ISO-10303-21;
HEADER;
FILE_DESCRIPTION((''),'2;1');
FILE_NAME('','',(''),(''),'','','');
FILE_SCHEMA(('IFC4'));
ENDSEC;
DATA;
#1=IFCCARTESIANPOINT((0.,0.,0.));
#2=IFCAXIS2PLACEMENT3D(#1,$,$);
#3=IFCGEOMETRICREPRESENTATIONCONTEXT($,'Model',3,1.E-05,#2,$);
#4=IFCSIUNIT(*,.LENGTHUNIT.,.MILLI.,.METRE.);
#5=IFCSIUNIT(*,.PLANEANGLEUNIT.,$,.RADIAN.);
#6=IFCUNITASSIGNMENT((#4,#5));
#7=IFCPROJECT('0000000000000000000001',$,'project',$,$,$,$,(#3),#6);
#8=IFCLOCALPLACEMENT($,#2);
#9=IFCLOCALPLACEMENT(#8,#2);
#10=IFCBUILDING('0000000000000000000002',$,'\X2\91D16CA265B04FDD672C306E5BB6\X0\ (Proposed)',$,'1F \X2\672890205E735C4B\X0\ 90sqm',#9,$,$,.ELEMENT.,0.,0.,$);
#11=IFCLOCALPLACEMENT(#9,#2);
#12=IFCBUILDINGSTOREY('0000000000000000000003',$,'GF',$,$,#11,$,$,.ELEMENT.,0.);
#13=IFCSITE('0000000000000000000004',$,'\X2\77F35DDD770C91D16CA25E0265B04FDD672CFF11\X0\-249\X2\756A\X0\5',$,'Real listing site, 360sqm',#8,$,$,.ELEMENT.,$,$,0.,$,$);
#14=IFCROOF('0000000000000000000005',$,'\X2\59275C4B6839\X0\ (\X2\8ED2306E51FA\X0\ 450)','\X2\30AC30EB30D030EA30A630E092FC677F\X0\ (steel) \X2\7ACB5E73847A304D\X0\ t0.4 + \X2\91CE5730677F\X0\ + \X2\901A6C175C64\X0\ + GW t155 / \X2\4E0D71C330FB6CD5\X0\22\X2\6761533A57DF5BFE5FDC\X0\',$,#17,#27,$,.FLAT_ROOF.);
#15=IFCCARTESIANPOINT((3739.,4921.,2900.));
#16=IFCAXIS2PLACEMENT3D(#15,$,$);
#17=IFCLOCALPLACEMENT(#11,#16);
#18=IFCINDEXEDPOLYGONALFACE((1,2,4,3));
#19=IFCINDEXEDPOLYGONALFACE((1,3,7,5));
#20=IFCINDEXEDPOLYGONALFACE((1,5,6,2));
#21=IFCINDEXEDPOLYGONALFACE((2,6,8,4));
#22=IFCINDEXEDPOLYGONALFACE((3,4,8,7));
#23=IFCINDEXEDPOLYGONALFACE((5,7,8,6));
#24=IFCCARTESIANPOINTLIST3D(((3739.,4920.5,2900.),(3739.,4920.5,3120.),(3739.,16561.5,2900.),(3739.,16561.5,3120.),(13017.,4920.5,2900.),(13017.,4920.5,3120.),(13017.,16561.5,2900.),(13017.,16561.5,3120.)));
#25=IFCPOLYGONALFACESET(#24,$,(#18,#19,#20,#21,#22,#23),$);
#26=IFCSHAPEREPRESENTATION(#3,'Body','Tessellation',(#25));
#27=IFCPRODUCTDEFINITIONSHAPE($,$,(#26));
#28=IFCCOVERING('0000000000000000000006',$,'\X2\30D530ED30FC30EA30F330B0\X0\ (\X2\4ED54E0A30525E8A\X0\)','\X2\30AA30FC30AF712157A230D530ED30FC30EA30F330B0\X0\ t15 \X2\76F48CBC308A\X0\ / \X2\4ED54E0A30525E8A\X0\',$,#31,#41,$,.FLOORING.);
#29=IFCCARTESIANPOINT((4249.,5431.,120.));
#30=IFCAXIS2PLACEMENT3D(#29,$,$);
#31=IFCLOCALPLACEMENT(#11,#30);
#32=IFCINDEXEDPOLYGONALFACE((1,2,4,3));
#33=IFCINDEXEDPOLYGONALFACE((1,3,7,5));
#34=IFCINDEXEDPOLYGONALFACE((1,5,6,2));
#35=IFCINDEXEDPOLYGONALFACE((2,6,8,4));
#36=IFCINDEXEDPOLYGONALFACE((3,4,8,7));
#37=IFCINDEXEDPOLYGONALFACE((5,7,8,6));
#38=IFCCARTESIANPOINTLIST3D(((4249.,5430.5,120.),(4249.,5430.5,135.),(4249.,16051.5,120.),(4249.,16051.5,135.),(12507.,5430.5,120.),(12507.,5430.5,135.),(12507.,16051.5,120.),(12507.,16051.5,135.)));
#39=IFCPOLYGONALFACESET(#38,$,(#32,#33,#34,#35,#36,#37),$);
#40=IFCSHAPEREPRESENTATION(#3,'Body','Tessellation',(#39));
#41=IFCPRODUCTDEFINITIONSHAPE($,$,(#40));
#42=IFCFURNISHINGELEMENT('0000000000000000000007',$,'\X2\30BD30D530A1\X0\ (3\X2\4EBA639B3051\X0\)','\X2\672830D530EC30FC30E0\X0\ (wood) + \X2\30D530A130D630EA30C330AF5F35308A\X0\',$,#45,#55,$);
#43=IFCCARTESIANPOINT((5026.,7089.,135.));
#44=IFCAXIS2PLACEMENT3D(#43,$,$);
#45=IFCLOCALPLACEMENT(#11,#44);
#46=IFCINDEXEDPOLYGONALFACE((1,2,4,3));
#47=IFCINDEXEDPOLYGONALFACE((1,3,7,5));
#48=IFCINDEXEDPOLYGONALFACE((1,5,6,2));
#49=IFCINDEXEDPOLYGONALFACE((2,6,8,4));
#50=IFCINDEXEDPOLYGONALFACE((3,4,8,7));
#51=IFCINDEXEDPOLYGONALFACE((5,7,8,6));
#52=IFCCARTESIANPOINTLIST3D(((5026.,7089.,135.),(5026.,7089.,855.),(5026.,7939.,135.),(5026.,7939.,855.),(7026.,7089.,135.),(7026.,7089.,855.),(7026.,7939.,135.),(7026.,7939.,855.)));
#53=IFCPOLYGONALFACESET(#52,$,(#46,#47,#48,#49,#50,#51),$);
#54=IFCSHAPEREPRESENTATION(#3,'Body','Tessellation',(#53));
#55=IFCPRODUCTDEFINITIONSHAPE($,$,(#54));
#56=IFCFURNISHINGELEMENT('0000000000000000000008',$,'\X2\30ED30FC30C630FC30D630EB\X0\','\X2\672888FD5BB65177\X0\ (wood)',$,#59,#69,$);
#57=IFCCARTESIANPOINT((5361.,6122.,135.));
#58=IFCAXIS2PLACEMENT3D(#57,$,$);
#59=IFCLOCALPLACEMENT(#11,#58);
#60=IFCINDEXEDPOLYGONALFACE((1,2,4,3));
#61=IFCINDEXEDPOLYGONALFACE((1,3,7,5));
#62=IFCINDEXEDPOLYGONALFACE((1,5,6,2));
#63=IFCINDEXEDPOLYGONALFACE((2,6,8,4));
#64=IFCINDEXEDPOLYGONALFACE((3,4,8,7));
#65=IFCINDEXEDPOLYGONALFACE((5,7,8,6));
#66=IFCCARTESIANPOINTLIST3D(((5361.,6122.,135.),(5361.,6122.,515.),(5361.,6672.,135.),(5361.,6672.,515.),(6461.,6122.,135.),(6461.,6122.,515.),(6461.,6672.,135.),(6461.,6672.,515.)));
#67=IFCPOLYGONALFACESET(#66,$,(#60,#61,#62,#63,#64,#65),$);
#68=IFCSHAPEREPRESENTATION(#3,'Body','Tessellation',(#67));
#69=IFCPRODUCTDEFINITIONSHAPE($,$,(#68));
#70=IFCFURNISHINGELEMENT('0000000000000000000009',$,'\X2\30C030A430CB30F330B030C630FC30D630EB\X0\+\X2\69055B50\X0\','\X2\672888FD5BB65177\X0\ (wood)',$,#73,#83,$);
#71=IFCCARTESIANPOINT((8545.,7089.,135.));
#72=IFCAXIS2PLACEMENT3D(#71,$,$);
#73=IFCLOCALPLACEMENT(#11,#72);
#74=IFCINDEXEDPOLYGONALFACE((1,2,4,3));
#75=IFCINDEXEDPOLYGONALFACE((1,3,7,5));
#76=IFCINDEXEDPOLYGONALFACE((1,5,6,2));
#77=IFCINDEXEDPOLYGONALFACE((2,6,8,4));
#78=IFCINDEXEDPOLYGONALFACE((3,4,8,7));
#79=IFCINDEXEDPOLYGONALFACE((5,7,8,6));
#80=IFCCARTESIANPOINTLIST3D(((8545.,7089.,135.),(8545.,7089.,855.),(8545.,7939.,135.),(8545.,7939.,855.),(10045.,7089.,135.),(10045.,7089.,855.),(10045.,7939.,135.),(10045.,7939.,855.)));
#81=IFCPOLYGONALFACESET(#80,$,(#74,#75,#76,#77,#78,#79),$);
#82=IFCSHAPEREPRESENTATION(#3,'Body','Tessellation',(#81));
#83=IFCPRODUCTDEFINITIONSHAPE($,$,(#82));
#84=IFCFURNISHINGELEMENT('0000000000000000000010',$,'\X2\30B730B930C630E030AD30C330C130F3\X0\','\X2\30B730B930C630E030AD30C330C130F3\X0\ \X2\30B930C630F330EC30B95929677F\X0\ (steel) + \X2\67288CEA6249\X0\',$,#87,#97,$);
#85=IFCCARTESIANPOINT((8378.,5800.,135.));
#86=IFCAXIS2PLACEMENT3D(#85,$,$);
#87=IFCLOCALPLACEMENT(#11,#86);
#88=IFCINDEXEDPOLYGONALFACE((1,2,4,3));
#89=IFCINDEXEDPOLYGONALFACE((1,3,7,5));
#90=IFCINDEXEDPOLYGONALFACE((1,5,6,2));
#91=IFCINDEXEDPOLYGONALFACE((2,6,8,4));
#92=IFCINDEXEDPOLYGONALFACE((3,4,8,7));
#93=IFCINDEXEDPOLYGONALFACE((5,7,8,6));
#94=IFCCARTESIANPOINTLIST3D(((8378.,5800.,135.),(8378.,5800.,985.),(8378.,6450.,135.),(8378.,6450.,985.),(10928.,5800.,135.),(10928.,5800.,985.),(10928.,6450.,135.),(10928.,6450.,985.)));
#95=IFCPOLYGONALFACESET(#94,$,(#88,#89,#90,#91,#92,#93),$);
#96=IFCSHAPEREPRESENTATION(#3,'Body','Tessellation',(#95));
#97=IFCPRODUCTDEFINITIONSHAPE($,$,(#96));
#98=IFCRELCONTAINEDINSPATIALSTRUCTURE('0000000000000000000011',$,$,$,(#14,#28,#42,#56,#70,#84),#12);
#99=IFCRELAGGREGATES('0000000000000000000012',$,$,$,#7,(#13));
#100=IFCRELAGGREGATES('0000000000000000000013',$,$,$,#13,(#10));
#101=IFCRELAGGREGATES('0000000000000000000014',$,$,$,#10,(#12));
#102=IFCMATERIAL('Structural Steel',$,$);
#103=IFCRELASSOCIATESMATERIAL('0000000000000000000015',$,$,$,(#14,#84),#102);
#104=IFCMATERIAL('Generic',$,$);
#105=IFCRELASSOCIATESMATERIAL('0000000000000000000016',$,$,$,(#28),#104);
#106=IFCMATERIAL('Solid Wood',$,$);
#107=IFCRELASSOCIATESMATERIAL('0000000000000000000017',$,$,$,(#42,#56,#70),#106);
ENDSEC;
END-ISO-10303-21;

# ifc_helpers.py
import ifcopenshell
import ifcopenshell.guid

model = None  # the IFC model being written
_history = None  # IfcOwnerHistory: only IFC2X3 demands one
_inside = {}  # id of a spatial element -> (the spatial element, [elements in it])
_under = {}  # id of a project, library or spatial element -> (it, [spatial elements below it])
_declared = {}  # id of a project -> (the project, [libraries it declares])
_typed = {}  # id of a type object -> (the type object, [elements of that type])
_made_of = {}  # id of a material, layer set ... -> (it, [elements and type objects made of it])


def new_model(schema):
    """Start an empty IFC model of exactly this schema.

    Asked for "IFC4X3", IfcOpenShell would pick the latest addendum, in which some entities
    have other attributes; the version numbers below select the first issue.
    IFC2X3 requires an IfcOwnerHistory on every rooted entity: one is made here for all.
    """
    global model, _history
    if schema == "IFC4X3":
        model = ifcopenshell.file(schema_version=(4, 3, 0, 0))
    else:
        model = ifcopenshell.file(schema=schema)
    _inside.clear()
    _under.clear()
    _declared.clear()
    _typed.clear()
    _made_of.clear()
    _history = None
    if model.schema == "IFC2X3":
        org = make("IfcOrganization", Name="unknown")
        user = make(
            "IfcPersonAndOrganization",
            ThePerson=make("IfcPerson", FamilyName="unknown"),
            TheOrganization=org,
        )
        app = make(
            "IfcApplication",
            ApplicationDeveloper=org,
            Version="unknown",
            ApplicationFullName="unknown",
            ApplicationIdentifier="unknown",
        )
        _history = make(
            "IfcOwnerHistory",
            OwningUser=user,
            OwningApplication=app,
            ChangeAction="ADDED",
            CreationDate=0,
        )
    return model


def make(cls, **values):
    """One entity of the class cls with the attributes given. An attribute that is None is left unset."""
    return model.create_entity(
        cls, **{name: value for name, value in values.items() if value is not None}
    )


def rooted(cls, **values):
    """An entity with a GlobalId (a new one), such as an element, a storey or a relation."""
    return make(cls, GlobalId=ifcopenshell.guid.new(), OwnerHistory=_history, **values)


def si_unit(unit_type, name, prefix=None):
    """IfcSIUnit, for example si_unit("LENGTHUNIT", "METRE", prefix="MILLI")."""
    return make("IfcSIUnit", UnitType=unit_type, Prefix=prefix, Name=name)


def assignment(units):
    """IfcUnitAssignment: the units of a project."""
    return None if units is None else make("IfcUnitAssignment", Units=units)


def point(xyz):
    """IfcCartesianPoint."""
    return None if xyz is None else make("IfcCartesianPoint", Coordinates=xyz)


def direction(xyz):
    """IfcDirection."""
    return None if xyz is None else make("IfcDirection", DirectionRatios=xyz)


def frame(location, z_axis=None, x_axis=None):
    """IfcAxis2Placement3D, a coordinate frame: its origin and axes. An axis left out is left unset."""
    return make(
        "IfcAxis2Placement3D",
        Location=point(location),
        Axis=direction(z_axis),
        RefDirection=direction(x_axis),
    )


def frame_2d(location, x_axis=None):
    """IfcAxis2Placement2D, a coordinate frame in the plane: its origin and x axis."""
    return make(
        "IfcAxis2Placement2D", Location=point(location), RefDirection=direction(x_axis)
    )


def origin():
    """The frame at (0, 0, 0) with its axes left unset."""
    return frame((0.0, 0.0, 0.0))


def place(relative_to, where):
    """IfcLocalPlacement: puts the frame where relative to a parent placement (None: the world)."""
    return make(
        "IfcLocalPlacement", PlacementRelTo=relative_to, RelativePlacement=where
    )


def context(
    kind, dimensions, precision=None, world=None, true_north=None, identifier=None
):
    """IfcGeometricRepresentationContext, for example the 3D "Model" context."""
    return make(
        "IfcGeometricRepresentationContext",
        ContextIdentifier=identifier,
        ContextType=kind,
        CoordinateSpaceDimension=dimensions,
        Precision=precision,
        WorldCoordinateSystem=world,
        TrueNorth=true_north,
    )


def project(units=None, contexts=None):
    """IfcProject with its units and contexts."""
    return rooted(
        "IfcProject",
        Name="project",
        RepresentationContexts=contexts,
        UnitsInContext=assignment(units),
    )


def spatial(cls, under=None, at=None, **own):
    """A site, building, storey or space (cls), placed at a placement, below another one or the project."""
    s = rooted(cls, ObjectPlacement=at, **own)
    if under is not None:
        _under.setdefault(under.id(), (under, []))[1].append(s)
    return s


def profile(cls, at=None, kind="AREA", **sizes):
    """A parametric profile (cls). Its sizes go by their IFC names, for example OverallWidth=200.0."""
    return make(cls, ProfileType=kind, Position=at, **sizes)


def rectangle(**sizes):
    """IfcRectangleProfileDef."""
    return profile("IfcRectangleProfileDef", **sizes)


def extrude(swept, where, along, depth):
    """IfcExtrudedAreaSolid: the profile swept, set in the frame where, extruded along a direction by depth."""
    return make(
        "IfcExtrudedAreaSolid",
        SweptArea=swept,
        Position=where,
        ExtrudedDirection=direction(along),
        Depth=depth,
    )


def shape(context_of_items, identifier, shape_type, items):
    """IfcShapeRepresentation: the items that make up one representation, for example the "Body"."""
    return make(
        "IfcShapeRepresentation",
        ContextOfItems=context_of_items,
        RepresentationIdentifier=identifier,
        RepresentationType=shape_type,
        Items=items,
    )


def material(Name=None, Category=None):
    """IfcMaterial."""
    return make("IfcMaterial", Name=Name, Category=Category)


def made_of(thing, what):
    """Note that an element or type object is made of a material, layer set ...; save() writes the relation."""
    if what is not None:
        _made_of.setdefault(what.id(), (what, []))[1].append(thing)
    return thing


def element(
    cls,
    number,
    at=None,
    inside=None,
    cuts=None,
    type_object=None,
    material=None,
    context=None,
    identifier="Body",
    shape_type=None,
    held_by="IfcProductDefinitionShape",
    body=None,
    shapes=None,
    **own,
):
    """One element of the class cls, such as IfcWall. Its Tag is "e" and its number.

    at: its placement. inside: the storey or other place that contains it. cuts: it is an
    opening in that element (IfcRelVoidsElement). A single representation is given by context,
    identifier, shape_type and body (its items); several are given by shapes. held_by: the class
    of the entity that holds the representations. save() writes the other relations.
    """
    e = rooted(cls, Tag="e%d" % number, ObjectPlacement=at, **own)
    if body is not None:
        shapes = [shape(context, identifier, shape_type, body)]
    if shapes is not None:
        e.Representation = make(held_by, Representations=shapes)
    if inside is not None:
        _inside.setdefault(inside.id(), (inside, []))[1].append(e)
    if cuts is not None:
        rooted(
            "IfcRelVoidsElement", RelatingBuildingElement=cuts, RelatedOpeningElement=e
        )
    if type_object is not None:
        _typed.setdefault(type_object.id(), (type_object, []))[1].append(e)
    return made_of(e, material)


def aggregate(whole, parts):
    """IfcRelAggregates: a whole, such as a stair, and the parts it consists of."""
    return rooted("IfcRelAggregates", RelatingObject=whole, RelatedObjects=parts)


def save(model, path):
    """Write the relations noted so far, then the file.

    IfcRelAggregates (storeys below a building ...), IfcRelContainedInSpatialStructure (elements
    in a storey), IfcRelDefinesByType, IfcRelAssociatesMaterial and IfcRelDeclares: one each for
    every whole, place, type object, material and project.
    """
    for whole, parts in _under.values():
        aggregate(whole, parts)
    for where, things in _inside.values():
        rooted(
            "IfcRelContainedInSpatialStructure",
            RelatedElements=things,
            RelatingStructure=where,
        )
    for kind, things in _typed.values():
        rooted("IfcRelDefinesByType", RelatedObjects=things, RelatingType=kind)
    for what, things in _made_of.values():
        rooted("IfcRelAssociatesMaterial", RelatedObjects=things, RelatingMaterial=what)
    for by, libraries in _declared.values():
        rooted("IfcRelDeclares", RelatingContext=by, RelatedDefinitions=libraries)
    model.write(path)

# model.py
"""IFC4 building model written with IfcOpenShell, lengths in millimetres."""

from ifc_helpers import new_model, si_unit, frame, frame_2d, origin, place, context, project, spatial, rectangle, extrude, material, element, save


model = new_model("IFC4")

# Units and contexts
model_context = context("Model", 3, precision=1e-05, world=origin())
ifc_project = project(units=[si_unit("LENGTHUNIT", "METRE", prefix="MILLI"), si_unit("PLANEANGLEUNIT", "RADIAN")], contexts=[model_context])

# Site, building, storey
site_placement = place(None, origin())
site = spatial("IfcSite", under=ifc_project, at=site_placement, Name="石川県金沢市新保本１-249番5", ObjectType="Real listing site, 360sqm", CompositionType="ELEMENT", RefElevation=0.0)
building_placement = place(site_placement, origin())
building = spatial("IfcBuilding", under=site, at=building_placement, Name="金沢新保本の家 (Proposed)", ObjectType="1F 木造平屋 90sqm", CompositionType="ELEMENT", ElevationOfRefHeight=0.0, ElevationOfTerrain=0.0)
storey_placement = place(building_placement, origin())
storey = spatial("IfcBuildingStorey", under=building, at=storey_placement, Name="GF", CompositionType="ELEMENT", Elevation=0.0)

# Shared definitions
ifc_material_1 = material(Name="Solid Wood")

# Roof
ifc_material_2 = material(Name="Structural Steel")
roof_placement = place(storey_placement, frame((3739.0, 4921.0, 2900.0)))
element("IfcRoof", 1, at=roof_placement, inside=storey, material=ifc_material_2, Name="大屋根 (軒の出 450)", Description="ガルバリウム鋼板 (steel) 立平葺き t0.4 + 野地板 + 通気層 + GW t155 / 不燃・法22条区域対応", PredefinedType="FLAT_ROOF", context=model_context, shape_type="SweptSolid", body=[
    extrude(rectangle(XDim=9278.0, YDim=11641.0, at=frame_2d((4639.0, 5820.0))), frame((3739.0, 4921.0, 2900.0)), (0.0, 0.0, 1.0), 220.0),
])

# Covering
ifc_material_3 = material(Name="Generic")
covering_placement = place(storey_placement, frame((4249.0, 5431.0, 120.0)))
element("IfcCovering", 2, at=covering_placement, inside=storey, material=ifc_material_3, Name="フローリング (仕上げ床)", Description="オーク無垢フローリング t15 直貼り / 仕上げ床", PredefinedType="FLOORING", context=model_context, shape_type="SweptSolid", body=[
    extrude(rectangle(XDim=8258.0, YDim=10621.0, at=frame_2d((4129.0, 5310.0))), frame((4249.0, 5431.0, 120.0)), (0.0, 0.0, 1.0), 15.0),
])

# Furnishing elements
furnishing_1_placement = place(storey_placement, frame((5026.0, 7089.0, 135.0)))
element("IfcFurnishingElement", 3, at=furnishing_1_placement, inside=storey, material=ifc_material_1, Name="ソファ (3人掛け)", Description="木フレーム (wood) + ファブリック張り", context=model_context, shape_type="SweptSolid", body=[
    extrude(rectangle(XDim=2000.0, YDim=850.0, at=frame_2d((1000.0, 425.0))), frame((5026.0, 7089.0, 135.0)), (0.0, 0.0, 1.0), 720.0),
])
furnishing_2_placement = place(storey_placement, frame((5361.0, 6122.0, 135.0)))
element("IfcFurnishingElement", 4, at=furnishing_2_placement, inside=storey, material=ifc_material_1, Name="ローテーブル", Description="木製家具 (wood)", context=model_context, shape_type="SweptSolid", body=[
    extrude(rectangle(XDim=1100.0, YDim=550.0, at=frame_2d((550.0, 275.0))), frame((5361.0, 6122.0, 135.0)), (0.0, 0.0, 1.0), 380.0),
])
furnishing_3_placement = place(storey_placement, frame((8545.0, 7089.0, 135.0)))
element("IfcFurnishingElement", 5, at=furnishing_3_placement, inside=storey, material=ifc_material_1, Name="ダイニングテーブル+椅子", Description="木製家具 (wood)", context=model_context, shape_type="SweptSolid", body=[
    extrude(rectangle(XDim=1500.0, YDim=850.0, at=frame_2d((750.0, 425.0))), frame((8545.0, 7089.0, 135.0)), (0.0, 0.0, 1.0), 720.0),
])
furnishing_4_placement = place(storey_placement, frame((8378.0, 5800.0, 135.0)))
element("IfcFurnishingElement", 6, at=furnishing_4_placement, inside=storey, material=ifc_material_2, Name="システムキッチン", Description="システムキッチン ステンレス天板 (steel) + 木質扉", context=model_context, shape_type="SweptSolid", body=[
    extrude(rectangle(XDim=2550.0, YDim=650.0, at=frame_2d((1275.0, 325.0))), frame((8378.0, 5800.0, 135.0)), (0.0, 0.0, 1.0), 850.0),
])

save(model, "model.ifc")
